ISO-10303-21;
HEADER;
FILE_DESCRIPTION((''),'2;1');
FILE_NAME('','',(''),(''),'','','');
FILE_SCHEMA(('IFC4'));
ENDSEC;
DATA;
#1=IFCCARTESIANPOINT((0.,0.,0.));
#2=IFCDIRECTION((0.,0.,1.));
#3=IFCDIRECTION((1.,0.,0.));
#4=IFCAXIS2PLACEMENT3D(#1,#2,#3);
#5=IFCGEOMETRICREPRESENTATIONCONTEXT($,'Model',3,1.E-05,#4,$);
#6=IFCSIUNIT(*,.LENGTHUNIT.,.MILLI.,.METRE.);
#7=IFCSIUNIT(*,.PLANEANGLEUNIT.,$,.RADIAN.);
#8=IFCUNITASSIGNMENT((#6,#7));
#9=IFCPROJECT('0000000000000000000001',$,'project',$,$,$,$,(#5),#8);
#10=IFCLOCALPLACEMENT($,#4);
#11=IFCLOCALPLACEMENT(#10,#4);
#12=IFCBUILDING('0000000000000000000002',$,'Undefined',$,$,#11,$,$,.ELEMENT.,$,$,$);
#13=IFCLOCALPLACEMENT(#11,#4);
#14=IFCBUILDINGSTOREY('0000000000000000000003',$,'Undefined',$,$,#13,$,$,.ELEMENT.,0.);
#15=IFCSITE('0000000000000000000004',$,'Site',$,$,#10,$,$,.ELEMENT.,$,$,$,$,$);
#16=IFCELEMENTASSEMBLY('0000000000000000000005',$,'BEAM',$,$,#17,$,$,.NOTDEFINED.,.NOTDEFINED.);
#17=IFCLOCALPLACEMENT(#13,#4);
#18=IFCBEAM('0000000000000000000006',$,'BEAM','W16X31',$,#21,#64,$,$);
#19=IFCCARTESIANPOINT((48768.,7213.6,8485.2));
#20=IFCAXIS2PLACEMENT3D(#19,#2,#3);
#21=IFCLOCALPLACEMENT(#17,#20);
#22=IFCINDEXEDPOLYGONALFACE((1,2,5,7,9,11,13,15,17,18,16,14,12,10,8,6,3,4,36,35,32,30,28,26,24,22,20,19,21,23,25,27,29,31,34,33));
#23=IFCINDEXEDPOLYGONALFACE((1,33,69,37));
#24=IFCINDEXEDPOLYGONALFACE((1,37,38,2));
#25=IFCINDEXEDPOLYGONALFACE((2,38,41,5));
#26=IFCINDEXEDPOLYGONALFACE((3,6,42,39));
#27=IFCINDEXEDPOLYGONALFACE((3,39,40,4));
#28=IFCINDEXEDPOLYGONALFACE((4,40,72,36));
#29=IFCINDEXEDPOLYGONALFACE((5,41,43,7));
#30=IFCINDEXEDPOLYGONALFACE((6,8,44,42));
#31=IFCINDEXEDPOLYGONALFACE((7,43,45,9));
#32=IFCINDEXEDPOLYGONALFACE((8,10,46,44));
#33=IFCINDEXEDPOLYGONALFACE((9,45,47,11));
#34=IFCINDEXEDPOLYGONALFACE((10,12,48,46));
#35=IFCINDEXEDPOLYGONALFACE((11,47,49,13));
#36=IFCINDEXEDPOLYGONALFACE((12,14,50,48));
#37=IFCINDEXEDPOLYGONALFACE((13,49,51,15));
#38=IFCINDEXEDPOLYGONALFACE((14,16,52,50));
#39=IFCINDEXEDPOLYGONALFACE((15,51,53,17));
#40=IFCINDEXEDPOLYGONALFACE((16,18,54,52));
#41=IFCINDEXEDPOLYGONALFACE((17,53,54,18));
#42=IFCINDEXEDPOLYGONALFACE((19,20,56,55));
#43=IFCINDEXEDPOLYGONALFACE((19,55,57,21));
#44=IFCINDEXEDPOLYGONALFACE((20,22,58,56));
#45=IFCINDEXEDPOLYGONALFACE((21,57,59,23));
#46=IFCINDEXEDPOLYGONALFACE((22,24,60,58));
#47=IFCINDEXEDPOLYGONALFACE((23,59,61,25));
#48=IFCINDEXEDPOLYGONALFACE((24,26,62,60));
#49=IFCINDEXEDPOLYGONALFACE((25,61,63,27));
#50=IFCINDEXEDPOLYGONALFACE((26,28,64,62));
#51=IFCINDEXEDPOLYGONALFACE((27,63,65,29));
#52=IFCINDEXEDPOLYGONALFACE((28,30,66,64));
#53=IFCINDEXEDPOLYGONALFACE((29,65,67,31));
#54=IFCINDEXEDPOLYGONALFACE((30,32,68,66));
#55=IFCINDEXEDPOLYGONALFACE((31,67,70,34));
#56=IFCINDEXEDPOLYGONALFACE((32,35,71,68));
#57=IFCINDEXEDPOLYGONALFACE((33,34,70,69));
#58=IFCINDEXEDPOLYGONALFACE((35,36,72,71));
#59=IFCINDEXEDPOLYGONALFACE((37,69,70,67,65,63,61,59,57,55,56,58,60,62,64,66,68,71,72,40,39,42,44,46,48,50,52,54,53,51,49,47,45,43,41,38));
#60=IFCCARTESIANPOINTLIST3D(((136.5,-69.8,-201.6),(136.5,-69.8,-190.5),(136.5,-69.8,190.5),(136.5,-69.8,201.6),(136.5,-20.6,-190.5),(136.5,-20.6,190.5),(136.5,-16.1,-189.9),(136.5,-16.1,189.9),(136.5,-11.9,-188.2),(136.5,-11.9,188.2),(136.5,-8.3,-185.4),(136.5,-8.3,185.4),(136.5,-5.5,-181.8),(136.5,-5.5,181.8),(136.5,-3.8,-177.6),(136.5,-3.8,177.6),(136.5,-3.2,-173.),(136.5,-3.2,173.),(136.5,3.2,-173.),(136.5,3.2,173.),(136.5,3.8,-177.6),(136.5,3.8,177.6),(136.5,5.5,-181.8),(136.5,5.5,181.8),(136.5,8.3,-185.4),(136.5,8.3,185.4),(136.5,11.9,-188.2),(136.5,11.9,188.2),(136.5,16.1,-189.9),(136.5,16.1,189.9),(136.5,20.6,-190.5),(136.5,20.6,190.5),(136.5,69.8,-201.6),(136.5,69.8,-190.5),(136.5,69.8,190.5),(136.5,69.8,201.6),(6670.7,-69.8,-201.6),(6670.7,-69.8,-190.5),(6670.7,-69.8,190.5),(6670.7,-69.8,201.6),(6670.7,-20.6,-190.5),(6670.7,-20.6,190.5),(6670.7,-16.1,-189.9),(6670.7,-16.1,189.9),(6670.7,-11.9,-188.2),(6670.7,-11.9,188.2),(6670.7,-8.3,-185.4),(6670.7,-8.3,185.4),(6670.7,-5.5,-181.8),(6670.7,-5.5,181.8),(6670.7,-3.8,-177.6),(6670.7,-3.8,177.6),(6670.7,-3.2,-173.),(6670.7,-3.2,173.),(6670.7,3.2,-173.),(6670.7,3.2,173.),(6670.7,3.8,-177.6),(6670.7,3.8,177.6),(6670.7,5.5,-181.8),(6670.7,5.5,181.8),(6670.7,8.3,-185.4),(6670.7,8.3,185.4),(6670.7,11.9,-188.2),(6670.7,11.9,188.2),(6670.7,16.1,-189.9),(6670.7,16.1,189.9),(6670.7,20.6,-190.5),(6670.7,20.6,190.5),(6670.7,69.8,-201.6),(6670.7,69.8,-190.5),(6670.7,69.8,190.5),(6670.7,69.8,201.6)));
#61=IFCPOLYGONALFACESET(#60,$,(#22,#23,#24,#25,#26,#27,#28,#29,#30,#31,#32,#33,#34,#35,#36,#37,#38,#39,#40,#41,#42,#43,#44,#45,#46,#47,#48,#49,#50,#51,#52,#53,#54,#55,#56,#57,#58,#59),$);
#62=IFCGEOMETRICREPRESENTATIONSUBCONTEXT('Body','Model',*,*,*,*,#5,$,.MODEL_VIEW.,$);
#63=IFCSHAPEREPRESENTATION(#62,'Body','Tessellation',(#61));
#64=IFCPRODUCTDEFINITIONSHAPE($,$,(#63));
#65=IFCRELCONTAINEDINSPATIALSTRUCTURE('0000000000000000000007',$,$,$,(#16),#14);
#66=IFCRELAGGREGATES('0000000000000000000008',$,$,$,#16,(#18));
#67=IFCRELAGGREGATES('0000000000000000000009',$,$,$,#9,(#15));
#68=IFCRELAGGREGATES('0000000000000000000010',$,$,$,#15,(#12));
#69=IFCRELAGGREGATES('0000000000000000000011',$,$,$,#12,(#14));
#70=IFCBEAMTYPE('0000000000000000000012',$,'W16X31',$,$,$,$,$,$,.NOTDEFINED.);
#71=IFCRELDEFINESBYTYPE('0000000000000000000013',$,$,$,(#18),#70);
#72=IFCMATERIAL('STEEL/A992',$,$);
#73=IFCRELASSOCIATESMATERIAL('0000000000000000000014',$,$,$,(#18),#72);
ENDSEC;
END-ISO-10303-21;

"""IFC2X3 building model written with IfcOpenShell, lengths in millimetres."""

from ifc_helpers import new_model, si_unit, frame, origin_with_axes, origin_2d_with_axis, place, context, subcontext, project, spatial, i_section, extrude, clip, halfspace, material, type_object, element, aggregate, save


model = new_model("IFC2X3")

# Units and contexts
model_context = context("Model", 3, precision=1e-05, world=origin_with_axes())
body_context = subcontext(model_context, "Body", "Model", "MODEL_VIEW")
ifc_project = project(units=[si_unit("LENGTHUNIT", "METRE", prefix="MILLI"), si_unit("PLANEANGLEUNIT", "RADIAN")], contexts=[model_context])

# Site, building, storey
site_placement = place(None, origin_with_axes())
site = spatial("IfcSite", under=ifc_project, at=site_placement, Name="Site", CompositionType="ELEMENT")
building_placement = place(site_placement, origin_with_axes())
building = spatial("IfcBuilding", under=site, at=building_placement, Name="Undefined", CompositionType="ELEMENT")
storey_placement = place(building_placement, origin_with_axes())
storey = spatial("IfcBuildingStorey", under=building, at=storey_placement, Name="Undefined", CompositionType="ELEMENT", Elevation=0.0)

# Shared definitions
ifc_material_1 = material(Name="STEEL/A992")

# Element assembly, beam
beam_type_1 = type_object("IfcBeamType", Name="W16X31", PredefinedType="NOTDEFINED")
assembly_1_placement = place(storey_placement, origin_with_axes())
assembly_1 = element("IfcElementAssembly", 1, at=assembly_1_placement, inside=storey, Name="BEAM", AssemblyPlace="NOTDEFINED", PredefinedType="NOTDEFINED")
beam_1_placement = place(assembly_1_placement, frame((48768.0, 7213.6, 8485.2), z_axis=(0.0, 0.0, 1.0), x_axis=(1.0, 0.0, 0.0)))
beam_1 = element("IfcBeam", 2, at=beam_1_placement, type_object=beam_type_1, material=ifc_material_1, Name="BEAM", Description="W16X31", context=body_context, shape_type="Clipping", body=[
    clip(clip(extrude(i_section(OverallWidth=139.7, OverallDepth=403.2, WebThickness=6.3, FlangeThickness=11.1, FilletRadius=17.5, at=origin_2d_with_axis()), frame((6807.2, 0.0, 0.0), z_axis=(-1.0, 0.0, 0.0), x_axis=(0.0, -1.0, 0.0)), (0.0, 0.0, 1.0), 6807.2), halfspace(frame((6670.7, 0.0, 301.6), z_axis=(1.0, 0.0, 0.0), x_axis=(0.0, 1.0, 0.0)), False)), halfspace(frame((136.5, 0.0, 301.6), z_axis=(-1.0, 0.0, 0.0), x_axis=(0.0, -1.0, 0.0)), False)),
])
aggregate(assembly_1, [beam_1])

save(model, "model.ifc")
